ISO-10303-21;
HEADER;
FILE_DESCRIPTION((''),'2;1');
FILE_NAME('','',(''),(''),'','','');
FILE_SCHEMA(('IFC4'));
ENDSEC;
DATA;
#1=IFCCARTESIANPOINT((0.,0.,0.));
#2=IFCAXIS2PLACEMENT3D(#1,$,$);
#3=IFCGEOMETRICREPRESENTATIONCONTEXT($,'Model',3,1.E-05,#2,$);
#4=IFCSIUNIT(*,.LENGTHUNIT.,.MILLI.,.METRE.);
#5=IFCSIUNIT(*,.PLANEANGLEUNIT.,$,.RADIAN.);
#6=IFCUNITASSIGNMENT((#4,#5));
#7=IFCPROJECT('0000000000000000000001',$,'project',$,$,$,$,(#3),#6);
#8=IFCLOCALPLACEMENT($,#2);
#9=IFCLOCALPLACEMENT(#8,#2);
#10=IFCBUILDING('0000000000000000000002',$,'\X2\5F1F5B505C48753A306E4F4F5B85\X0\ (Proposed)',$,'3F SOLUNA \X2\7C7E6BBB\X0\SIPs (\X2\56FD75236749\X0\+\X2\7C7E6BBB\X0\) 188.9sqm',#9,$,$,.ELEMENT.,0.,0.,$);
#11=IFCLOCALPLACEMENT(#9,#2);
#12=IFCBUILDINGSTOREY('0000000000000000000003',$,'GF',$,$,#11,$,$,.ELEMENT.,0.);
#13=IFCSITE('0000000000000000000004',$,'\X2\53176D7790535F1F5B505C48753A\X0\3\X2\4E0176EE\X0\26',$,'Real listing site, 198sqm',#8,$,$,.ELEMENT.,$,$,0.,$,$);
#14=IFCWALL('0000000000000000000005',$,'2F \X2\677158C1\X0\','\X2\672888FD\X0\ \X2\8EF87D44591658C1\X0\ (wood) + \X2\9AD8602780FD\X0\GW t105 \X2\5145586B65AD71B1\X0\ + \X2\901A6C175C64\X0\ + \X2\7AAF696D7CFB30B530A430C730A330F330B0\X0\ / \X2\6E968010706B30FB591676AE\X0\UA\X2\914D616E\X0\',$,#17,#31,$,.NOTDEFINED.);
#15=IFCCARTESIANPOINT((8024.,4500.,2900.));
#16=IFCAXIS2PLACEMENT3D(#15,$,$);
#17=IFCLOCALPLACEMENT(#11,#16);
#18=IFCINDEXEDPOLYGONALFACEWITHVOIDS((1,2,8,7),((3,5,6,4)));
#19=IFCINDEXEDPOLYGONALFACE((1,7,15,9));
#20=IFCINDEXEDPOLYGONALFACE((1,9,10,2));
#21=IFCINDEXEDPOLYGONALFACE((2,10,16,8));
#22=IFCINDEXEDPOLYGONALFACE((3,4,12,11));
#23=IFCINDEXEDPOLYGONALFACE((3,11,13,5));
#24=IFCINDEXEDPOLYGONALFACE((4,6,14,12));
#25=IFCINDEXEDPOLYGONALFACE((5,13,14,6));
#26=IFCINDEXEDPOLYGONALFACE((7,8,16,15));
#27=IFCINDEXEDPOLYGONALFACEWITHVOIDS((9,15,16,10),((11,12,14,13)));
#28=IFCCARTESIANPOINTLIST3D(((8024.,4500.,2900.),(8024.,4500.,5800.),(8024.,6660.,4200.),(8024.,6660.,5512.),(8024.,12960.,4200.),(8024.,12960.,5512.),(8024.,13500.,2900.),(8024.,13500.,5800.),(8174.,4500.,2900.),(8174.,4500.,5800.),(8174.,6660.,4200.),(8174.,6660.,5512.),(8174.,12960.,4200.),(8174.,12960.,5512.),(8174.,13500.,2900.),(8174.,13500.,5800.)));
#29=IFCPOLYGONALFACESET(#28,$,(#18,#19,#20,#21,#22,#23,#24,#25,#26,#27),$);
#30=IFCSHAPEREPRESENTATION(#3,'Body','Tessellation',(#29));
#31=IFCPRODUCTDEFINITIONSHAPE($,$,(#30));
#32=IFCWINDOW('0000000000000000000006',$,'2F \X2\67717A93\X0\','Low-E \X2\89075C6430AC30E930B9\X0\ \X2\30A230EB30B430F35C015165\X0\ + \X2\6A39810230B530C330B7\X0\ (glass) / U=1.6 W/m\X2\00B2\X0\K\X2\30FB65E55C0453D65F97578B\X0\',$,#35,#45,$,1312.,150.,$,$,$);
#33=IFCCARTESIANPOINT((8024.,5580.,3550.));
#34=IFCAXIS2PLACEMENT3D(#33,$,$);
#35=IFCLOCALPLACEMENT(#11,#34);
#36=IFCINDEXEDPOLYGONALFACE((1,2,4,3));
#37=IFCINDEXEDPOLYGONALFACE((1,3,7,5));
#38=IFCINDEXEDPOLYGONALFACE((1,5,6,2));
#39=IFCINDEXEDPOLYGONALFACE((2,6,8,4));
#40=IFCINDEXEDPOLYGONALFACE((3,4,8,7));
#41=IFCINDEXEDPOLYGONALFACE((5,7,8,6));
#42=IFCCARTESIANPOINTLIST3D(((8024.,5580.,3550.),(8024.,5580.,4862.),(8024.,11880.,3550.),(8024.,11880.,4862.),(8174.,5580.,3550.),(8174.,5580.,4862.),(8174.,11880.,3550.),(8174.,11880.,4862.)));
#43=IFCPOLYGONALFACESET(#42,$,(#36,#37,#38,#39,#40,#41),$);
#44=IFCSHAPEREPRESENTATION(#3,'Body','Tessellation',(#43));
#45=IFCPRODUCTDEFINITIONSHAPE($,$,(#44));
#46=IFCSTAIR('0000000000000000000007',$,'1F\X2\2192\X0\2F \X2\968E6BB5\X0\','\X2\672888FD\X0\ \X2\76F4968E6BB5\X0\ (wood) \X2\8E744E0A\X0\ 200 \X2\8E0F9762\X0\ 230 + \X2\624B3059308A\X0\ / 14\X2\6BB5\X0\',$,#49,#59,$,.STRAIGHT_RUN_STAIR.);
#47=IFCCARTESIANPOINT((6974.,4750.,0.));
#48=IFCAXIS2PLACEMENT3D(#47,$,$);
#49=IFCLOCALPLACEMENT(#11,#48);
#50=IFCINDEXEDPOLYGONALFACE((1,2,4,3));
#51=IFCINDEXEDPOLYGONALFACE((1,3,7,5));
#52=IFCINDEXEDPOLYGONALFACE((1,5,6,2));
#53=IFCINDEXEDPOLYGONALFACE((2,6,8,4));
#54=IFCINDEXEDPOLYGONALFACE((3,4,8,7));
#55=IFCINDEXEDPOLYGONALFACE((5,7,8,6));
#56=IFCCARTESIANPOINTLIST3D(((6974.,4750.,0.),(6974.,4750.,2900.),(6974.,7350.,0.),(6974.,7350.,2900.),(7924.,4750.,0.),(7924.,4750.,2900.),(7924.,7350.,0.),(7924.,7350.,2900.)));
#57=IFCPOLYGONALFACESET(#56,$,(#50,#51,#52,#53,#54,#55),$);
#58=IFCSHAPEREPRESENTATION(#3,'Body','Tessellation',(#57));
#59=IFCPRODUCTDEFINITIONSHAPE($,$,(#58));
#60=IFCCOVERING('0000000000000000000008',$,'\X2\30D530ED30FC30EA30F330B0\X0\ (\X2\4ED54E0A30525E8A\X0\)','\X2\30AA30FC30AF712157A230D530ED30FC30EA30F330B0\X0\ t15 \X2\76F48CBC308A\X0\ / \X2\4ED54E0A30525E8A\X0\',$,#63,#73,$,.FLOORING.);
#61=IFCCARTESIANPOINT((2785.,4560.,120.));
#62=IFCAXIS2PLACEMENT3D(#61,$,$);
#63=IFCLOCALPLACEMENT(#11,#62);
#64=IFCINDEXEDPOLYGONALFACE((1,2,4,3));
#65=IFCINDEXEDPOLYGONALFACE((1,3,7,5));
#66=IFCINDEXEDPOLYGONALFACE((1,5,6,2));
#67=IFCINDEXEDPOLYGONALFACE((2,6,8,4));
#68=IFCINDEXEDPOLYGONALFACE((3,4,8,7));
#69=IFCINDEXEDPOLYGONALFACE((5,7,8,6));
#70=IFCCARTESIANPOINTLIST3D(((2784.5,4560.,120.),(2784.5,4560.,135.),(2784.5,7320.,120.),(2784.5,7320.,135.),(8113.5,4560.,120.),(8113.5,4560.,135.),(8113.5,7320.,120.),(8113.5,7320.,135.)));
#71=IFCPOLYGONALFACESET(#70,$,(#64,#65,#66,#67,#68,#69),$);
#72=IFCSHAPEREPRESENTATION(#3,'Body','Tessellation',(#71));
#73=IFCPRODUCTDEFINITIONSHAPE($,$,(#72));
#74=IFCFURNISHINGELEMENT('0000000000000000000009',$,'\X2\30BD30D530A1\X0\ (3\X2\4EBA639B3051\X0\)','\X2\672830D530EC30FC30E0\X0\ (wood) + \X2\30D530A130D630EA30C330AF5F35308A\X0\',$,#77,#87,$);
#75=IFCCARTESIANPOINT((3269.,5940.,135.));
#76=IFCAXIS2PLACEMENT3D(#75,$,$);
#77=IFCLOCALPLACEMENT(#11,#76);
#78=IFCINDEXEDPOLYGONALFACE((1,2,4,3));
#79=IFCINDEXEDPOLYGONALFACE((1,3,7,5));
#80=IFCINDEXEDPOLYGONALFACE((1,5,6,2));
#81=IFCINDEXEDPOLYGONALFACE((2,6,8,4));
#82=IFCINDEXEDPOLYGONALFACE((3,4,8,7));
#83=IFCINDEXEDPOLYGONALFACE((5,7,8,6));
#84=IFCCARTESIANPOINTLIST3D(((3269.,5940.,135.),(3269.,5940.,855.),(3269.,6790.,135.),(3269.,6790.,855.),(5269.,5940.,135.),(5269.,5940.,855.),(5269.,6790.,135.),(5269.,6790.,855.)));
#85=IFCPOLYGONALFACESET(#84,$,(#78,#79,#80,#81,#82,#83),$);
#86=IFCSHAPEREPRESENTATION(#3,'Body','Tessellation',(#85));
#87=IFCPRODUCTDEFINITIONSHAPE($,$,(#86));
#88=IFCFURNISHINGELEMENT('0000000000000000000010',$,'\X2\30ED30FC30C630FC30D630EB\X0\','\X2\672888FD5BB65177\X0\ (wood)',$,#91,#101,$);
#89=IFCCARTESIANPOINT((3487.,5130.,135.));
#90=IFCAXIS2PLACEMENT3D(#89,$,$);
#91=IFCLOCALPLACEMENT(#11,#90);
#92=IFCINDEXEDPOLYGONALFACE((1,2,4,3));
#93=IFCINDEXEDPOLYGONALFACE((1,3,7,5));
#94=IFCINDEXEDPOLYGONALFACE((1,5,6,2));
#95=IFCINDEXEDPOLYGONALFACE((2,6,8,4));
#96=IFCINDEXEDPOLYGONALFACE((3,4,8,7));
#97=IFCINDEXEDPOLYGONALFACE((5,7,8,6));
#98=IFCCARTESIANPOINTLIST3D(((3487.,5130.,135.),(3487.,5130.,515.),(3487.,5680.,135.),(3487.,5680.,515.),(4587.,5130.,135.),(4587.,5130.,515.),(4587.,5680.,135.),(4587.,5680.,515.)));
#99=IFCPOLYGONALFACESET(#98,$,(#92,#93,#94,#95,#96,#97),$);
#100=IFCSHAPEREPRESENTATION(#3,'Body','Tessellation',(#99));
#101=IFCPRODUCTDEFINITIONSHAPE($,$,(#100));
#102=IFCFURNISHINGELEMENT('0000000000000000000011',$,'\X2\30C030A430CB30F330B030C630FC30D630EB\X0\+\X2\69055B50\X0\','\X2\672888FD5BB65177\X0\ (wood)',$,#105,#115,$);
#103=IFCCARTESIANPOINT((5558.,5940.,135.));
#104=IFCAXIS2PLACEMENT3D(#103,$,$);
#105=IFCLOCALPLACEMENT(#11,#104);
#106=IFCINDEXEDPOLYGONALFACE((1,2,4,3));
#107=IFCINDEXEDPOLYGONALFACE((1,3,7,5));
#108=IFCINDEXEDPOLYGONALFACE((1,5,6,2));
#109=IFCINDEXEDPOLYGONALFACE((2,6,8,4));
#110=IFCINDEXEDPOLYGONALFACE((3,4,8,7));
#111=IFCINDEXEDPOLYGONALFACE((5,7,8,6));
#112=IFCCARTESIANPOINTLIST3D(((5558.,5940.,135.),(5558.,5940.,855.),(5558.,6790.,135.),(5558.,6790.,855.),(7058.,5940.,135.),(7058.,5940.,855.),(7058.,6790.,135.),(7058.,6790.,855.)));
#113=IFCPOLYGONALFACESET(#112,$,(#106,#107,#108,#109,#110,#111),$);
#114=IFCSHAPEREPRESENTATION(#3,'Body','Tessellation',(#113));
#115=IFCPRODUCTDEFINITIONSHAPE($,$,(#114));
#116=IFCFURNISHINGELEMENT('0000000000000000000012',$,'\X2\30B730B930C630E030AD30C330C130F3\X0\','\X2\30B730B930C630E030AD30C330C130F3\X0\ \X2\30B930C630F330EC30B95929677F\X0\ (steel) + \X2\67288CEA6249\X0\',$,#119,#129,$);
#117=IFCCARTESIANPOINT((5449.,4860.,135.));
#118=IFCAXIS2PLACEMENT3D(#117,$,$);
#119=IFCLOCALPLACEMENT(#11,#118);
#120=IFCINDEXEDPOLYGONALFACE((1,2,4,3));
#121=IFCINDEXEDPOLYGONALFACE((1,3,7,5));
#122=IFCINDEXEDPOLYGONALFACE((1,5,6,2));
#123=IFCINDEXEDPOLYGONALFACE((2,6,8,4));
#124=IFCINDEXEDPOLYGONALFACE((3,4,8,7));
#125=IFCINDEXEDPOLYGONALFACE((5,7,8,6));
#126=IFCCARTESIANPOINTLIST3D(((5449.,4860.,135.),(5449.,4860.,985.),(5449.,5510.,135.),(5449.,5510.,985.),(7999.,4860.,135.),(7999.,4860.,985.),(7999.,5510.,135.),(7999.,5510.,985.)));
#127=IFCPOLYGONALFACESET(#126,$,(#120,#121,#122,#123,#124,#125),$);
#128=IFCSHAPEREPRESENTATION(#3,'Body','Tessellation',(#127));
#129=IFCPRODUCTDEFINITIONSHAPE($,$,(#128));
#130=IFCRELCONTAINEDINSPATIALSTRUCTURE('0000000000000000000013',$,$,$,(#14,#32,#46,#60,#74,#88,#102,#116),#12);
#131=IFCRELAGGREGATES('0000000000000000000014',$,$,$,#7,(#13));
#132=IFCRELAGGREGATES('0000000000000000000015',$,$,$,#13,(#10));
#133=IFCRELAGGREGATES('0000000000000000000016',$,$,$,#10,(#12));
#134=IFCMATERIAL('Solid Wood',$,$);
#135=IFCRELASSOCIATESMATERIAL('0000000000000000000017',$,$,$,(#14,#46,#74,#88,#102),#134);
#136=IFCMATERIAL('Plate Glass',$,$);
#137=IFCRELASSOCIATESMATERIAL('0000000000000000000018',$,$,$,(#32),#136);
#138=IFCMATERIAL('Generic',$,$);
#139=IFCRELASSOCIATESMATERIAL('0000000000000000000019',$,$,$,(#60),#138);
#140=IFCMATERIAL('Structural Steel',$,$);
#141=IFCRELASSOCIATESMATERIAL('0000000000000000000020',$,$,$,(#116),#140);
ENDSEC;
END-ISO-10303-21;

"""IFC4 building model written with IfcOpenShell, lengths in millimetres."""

from ifc_helpers import new_model, si_unit, frame, frame_2d, origin, place, context, project, spatial, rectangle, extrude, material, element, fill, save


model = new_model("IFC4")

# Units and contexts
model_context = context("Model", 3, precision=1e-05, world=origin())
ifc_project = project(units=[si_unit("LENGTHUNIT", "METRE", prefix="MILLI"), si_unit("PLANEANGLEUNIT", "RADIAN")], contexts=[model_context])

# Site, building, storey
site_placement = place(None, origin())
site = spatial("IfcSite", under=ifc_project, at=site_placement, Name="北海道弟子屈町3丁目26", ObjectType="Real listing site, 198sqm", CompositionType="ELEMENT", RefElevation=0.0)
building_placement = place(site_placement, origin())
building = spatial("IfcBuilding", under=site, at=building_placement, Name="弟子屈町の住宅 (Proposed)", ObjectType="3F SOLUNA 籾殻SIPs (国産杉+籾殻) 188.9sqm", CompositionType="ELEMENT", ElevationOfRefHeight=0.0, ElevationOfTerrain=0.0)
storey_placement = place(building_placement, origin())
storey = spatial("IfcBuildingStorey", under=building, at=storey_placement, Name="GF", CompositionType="ELEMENT", Elevation=0.0)

# Shared definitions
ifc_material_1 = material(Name="Solid Wood")
ifc_material_2 = material(Name="Generic")

# Shared definitions
ifc_material_3 = material(Name="Plate Glass")

# Wall, opening, window
wall_1_placement = place(storey_placement, frame((8024.0, 4500.0, 2900.0)))
wall_1 = element("IfcWall", 1, at=wall_1_placement, inside=storey, material=ifc_material_1, Name="2F 東壁", Description="木製 軸組外壁 (wood) + 高性能GW t105 充填断熱 + 通気層 + 窯業系サイディング / 準耐火・外皮UA配慮", PredefinedType="NOTDEFINED", context=model_context, shape_type="SweptSolid", body=[
    extrude(rectangle(XDim=150.0, YDim=9000.0, at=frame_2d((75.0, 4500.0))), frame((8024.0, 4500.0, 2900.0)), (0.0, 0.0, 1.0), 2900.0),
])
opening_1_placement = place(storey_placement, frame((8024.0, 5580.0, 3550.0)))
opening_1 = element("IfcOpeningElement", 2, at=opening_1_placement, cuts=wall_1, PredefinedType="NOTDEFINED", context=model_context, shape_type="SweptSolid", body=[
    extrude(rectangle(XDim=150.0, YDim=6300.0, at=frame_2d((75.0, 3150.0))), frame((8024.0, 5580.0, 3550.0)), (0.0, 0.0, 1.0), 1312.0),
])
window_1_placement = place(storey_placement, frame((8024.0, 5580.0, 3550.0)))
window_1 = element("IfcWindow", 3, at=window_1_placement, inside=storey, material=ifc_material_3, Name="2F 東窓", Description="Low-E 複層ガラス アルゴン封入 + 樹脂サッシ (glass) / U=1.6 W/m²K・日射取得型", OverallHeight=1312.0, OverallWidth=150.0, context=model_context, shape_type="SweptSolid", body=[
    extrude(rectangle(XDim=150.0, YDim=6300.0, at=frame_2d((75.0, 3150.0))), frame((8024.0, 5580.0, 3550.0)), (0.0, 0.0, 1.0), 1312.0),
])
fill(opening_1, window_1)

# Stair
stair_placement = place(storey_placement, frame((6974.0, 4750.0, 0.0)))
element("IfcStair", 4, at=stair_placement, inside=storey, material=ifc_material_1, Name="1F→2F 階段", Description="木製 直階段 (wood) 蹴上 200 踏面 230 + 手すり / 14段", PredefinedType="STRAIGHT_RUN_STAIR", context=model_context, shape_type="SweptSolid", body=[
    extrude(rectangle(XDim=950.0, YDim=2600.0, at=frame_2d((475.0, 1300.0))), frame((6974.0, 4750.0, 0.0)), (0.0, 0.0, 1.0), 2900.0),
])

# Covering
covering_placement = place(storey_placement, frame((2785.0, 4560.0, 120.0)))
element("IfcCovering", 5, at=covering_placement, inside=storey, material=ifc_material_2, Name="フローリング (仕上げ床)", Description="オーク無垢フローリング t15 直貼り / 仕上げ床", PredefinedType="FLOORING", context=model_context, shape_type="SweptSolid", body=[
    extrude(rectangle(XDim=5329.0, YDim=2760.0, at=frame_2d((2664.0, 1380.0))), frame((2785.0, 4560.0, 120.0)), (0.0, 0.0, 1.0), 15.0),
])

# Furnishing elements
furnishing_1_placement = place(storey_placement, frame((3269.0, 5940.0, 135.0)))
element("IfcFurnishingElement", 6, at=furnishing_1_placement, inside=storey, material=ifc_material_1, Name="ソファ (3人掛け)", Description="木フレーム (wood) + ファブリック張り", context=model_context, shape_type="SweptSolid", body=[
    extrude(rectangle(XDim=2000.0, YDim=850.0, at=frame_2d((1000.0, 425.0))), frame((3269.0, 5940.0, 135.0)), (0.0, 0.0, 1.0), 720.0),
])
furnishing_2_placement = place(storey_placement, frame((3487.0, 5130.0, 135.0)))
element("IfcFurnishingElement", 7, at=furnishing_2_placement, inside=storey, material=ifc_material_1, Name="ローテーブル", Description="木製家具 (wood)", context=model_context, shape_type="SweptSolid", body=[
    extrude(rectangle(XDim=1100.0, YDim=550.0, at=frame_2d((550.0, 275.0))), frame((3487.0, 5130.0, 135.0)), (0.0, 0.0, 1.0), 380.0),
])
furnishing_3_placement = place(storey_placement, frame((5558.0, 5940.0, 135.0)))
element("IfcFurnishingElement", 8, at=furnishing_3_placement, inside=storey, material=ifc_material_1, Name="ダイニングテーブル+椅子", Description="木製家具 (wood)", context=model_context, shape_type="SweptSolid", body=[
    extrude(rectangle(XDim=1500.0, YDim=850.0, at=frame_2d((750.0, 425.0))), frame((5558.0, 5940.0, 135.0)), (0.0, 0.0, 1.0), 720.0),
])
ifc_material_4 = material(Name="Structural Steel")
furnishing_4_placement = place(storey_placement, frame((5449.0, 4860.0, 135.0)))
element("IfcFurnishingElement", 9, at=furnishing_4_placement, inside=storey, material=ifc_material_4, Name="システムキッチン", Description="システムキッチン ステンレス天板 (steel) + 木質扉", context=model_context, shape_type="SweptSolid", body=[
    extrude(rectangle(XDim=2550.0, YDim=650.0, at=frame_2d((1275.0, 325.0))), frame((5449.0, 4860.0, 135.0)), (0.0, 0.0, 1.0), 850.0),
])

save(model, "model.ifc")
